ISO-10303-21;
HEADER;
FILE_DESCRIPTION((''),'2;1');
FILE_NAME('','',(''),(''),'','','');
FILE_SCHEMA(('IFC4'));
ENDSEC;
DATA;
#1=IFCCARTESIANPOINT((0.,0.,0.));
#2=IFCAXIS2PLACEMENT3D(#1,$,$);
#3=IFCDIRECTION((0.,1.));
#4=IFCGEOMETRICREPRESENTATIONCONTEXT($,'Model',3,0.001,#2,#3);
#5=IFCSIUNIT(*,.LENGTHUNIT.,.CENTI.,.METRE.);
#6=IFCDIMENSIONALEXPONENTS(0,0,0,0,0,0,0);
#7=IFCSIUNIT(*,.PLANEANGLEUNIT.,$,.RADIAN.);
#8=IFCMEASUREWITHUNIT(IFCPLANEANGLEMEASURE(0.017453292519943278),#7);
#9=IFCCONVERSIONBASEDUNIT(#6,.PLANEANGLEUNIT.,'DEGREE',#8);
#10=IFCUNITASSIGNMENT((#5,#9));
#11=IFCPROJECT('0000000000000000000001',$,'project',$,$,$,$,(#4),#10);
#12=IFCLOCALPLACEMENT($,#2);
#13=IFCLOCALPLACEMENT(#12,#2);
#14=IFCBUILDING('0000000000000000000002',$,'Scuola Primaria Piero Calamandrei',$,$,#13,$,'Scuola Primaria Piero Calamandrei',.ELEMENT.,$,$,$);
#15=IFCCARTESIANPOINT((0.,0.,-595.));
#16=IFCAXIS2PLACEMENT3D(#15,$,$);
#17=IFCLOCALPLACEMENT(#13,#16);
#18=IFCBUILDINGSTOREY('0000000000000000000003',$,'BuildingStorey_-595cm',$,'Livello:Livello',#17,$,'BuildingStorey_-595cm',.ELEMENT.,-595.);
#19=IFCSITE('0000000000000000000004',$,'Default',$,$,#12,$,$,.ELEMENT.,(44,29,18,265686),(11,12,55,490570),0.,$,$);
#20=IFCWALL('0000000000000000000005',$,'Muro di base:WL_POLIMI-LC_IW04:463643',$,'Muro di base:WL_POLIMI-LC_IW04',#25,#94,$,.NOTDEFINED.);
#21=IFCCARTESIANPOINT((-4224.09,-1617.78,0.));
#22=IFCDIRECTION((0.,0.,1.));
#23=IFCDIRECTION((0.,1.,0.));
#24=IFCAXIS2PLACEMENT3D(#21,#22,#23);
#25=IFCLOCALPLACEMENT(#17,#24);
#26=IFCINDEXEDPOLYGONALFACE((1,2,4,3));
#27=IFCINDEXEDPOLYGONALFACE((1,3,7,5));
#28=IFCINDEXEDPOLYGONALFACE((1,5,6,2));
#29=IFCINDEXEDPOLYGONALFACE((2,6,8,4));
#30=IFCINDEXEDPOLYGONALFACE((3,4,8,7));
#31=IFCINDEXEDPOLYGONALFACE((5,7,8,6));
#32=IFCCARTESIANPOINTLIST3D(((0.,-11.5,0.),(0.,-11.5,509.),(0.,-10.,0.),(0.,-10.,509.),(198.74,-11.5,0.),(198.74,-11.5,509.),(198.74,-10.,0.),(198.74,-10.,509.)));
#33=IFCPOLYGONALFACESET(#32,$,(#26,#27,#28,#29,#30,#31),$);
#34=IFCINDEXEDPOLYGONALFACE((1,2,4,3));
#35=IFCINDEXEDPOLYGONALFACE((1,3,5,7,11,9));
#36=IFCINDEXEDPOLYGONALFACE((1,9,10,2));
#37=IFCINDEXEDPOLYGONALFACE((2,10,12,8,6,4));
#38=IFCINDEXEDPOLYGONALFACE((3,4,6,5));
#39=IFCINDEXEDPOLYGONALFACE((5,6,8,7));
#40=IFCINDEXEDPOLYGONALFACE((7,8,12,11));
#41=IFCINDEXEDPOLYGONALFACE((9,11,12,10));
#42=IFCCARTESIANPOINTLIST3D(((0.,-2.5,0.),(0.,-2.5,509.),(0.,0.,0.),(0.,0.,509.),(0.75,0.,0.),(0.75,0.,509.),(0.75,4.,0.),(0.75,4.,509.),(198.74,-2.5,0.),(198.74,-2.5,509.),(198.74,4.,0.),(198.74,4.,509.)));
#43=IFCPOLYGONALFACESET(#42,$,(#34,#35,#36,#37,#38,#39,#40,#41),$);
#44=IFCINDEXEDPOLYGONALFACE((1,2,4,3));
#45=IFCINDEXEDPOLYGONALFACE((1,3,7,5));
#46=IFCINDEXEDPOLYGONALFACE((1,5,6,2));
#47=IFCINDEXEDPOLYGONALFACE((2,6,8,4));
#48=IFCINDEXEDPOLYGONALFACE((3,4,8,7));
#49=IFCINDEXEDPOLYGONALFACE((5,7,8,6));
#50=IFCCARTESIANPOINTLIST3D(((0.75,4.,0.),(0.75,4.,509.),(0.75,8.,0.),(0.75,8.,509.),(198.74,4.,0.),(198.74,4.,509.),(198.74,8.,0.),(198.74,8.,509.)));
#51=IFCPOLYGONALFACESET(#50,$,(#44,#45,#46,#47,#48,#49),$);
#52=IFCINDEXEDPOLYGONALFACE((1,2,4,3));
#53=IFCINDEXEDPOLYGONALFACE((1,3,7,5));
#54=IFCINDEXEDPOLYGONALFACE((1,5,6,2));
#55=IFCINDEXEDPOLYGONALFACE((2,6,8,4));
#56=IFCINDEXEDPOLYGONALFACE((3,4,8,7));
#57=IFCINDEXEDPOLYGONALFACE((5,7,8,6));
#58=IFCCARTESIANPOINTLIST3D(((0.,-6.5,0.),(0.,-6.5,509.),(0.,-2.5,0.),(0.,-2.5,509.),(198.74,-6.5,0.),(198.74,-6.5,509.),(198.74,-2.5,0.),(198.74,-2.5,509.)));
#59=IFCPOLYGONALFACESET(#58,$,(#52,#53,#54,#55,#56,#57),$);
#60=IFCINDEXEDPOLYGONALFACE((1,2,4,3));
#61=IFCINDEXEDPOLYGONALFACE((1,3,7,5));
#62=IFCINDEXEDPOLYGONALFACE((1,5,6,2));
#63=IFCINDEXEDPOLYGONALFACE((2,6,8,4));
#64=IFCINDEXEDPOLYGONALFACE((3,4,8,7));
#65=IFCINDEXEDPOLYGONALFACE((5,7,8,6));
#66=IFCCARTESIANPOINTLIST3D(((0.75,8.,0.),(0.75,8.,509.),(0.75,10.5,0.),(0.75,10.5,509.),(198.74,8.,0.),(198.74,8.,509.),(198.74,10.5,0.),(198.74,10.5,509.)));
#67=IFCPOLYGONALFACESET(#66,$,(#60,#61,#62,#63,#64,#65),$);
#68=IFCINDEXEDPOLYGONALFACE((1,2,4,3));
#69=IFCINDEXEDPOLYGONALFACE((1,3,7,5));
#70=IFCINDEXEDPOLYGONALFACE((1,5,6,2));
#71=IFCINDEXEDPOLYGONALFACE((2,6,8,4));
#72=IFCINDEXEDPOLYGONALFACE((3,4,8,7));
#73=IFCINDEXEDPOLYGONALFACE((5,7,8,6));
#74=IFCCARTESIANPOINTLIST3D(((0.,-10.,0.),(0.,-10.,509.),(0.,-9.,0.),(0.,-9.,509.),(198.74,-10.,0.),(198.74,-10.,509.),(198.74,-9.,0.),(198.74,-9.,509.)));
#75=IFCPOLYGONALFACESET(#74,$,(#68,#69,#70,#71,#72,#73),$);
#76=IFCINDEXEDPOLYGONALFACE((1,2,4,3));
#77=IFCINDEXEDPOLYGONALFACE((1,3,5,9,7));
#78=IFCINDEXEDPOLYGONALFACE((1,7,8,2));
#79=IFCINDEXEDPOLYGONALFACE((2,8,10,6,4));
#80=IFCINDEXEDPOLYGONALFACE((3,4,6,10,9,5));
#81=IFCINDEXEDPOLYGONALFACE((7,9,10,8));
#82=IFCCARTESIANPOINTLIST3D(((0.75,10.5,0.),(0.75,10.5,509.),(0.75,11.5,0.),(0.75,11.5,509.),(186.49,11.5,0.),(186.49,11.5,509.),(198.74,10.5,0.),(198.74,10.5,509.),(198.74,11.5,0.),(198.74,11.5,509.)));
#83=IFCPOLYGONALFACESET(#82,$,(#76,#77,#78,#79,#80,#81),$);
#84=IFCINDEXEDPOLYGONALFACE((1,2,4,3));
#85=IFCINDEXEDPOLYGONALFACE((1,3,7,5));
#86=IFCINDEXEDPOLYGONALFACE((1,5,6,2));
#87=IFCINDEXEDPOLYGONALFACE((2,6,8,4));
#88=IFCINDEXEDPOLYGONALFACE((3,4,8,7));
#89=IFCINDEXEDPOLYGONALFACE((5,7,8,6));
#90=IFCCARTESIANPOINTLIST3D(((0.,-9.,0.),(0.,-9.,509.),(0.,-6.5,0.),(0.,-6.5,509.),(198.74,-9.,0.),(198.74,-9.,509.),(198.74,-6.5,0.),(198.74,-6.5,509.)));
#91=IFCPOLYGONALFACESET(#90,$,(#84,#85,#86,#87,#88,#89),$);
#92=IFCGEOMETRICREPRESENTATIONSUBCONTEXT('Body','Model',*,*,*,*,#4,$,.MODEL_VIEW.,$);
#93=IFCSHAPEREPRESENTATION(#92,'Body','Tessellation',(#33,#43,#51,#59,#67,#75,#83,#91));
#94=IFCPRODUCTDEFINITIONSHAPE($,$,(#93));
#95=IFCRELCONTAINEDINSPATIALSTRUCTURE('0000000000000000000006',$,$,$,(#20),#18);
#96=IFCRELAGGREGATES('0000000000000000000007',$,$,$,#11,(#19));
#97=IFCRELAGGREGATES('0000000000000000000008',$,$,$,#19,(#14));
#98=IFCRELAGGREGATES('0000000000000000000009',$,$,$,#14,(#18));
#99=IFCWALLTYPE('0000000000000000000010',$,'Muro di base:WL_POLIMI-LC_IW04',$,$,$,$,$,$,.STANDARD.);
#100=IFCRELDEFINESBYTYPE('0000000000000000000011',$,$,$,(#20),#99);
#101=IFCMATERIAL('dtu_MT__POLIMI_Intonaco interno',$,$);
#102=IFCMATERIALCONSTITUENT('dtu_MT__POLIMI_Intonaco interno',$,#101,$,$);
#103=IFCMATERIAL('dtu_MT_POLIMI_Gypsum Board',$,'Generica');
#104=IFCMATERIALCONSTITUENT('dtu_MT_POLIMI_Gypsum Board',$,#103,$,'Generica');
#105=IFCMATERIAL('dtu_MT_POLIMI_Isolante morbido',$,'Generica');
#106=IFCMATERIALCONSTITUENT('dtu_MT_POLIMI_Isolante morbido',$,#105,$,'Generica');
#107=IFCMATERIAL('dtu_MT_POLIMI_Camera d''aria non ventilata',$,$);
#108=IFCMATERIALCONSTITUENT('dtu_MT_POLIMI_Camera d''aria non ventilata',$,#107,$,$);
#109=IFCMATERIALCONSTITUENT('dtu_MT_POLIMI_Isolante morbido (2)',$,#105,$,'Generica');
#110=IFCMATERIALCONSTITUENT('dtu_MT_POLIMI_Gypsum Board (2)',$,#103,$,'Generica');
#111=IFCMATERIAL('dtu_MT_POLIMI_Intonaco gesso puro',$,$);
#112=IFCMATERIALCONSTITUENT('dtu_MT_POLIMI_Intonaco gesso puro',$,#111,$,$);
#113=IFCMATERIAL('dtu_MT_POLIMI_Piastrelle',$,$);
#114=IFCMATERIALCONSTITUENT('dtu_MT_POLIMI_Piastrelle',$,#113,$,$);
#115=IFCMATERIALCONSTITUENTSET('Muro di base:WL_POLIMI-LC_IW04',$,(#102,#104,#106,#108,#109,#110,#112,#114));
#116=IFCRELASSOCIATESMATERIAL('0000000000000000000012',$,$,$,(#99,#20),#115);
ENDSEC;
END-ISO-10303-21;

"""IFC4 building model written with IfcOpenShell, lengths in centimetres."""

from ifc_helpers import new_model, entity, si_unit, converted_unit, direction, frame, origin, place, context, subcontext, project, spatial, indexed_curve, outline, extrude, material, constituent, constituent_set, type_object, element, save


model = new_model("IFC4")

# Units and contexts
model_context = context("Model", 3, precision=0.001, world=origin(), true_north=direction((0.0, 1.0)))
body_context = subcontext(model_context, "Body", "Model", "MODEL_VIEW")
ifc_project = project(units=[si_unit("LENGTHUNIT", "METRE", prefix="CENTI"), converted_unit("PLANEANGLEUNIT", "DEGREE", entity("IfcPlaneAngleMeasure", 0.017453292519943278), si_unit("PLANEANGLEUNIT", "RADIAN"), dimensions=[0, 0, 0, 0, 0, 0, 0])], contexts=[model_context])

# Site, building, storey
site_placement = place(None, origin())
site = spatial("IfcSite", under=ifc_project, at=site_placement, Name="Default", CompositionType="ELEMENT", RefLatitude=(44, 29, 18, 265686), RefLongitude=(11, 12, 55, 490570), RefElevation=0.0)
building_placement = place(site_placement, origin())
building = spatial("IfcBuilding", under=site, at=building_placement, Name="Scuola Primaria Piero Calamandrei", LongName="Scuola Primaria Piero Calamandrei", CompositionType="ELEMENT")
storey_placement = place(building_placement, frame((0.0, 0.0, -595.0)))
storey = spatial("IfcBuildingStorey", under=building, at=storey_placement, Name="BuildingStorey_-595cm", ObjectType="Livello:Livello", LongName="BuildingStorey_-595cm", CompositionType="ELEMENT", Elevation=-595.0)

# Shared definitions
ifc_material_1 = material(Name="dtu_MT__POLIMI_Intonaco interno")

# Shared definitions
ifc_material_2 = material(Name="dtu_MT_POLIMI_Gypsum Board", Category="Generica")
ifc_material_3 = material(Name="dtu_MT_POLIMI_Isolante morbido", Category="Generica")
ifc_material_4 = material(Name="dtu_MT_POLIMI_Camera d'aria non ventilata")
ifc_material_5 = material(Name="dtu_MT_POLIMI_Intonaco gesso puro")

# Shared definitions
ifc_constituent_1 = constituent(ifc_material_1, Name="dtu_MT__POLIMI_Intonaco interno")
ifc_constituent_2 = constituent(ifc_material_2, Name="dtu_MT_POLIMI_Gypsum Board", Category="Generica")
ifc_constituent_3 = constituent(ifc_material_3, Name="dtu_MT_POLIMI_Isolante morbido", Category="Generica")
ifc_constituent_4 = constituent(ifc_material_4, Name="dtu_MT_POLIMI_Camera d'aria non ventilata")
ifc_constituent_5 = constituent(ifc_material_3, Name="dtu_MT_POLIMI_Isolante morbido (2)", Category="Generica")
ifc_constituent_6 = constituent(ifc_material_2, Name="dtu_MT_POLIMI_Gypsum Board (2)", Category="Generica")
ifc_constituent_7 = constituent(ifc_material_5, Name="dtu_MT_POLIMI_Intonaco gesso puro")
ifc_material_6 = material(Name="dtu_MT_POLIMI_Piastrelle")
ifc_constituent_8 = constituent(ifc_material_6, Name="dtu_MT_POLIMI_Piastrelle")
ifc_constituent_set_1 = constituent_set(constituents=[ifc_constituent_1, ifc_constituent_2, ifc_constituent_3, ifc_constituent_4, ifc_constituent_5, ifc_constituent_6, ifc_constituent_7, ifc_constituent_8], Name="Muro di base:WL_POLIMI-LC_IW04")
wall_type_1 = type_object("IfcWallType", Name="Muro di base:WL_POLIMI-LC_IW04", PredefinedType="STANDARD", material=ifc_constituent_set_1)

# Wall
wall_1_placement = place(storey_placement, frame((-4224.09, -1617.78, 0.0), z_axis=(0.0, 0.0, 1.0), x_axis=(0.0, 1.0, 0.0)))
element("IfcWall", 1, at=wall_1_placement, inside=storey, type_object=wall_type_1, material=ifc_constituent_set_1, Name="Muro di base:WL_POLIMI-LC_IW04:463643", ObjectType="Muro di base:WL_POLIMI-LC_IW04", PredefinedType="NOTDEFINED", context=body_context, shape_type="SweptSolid", body=[
    extrude(outline(indexed_curve([(-0.75, -99.37), (0.75, -99.37), (0.75, 99.37), (-0.75, 99.37), (-0.75, -99.37)], self_intersect=False)), frame((99.37, -10.75, 0.0), z_axis=(0.0, 0.0, 1.0), x_axis=(0.0, 1.0, 0.0)), (0.0, 0.0, 1.0), 509.0),
    extrude(outline(indexed_curve([(0.5, -66.5), (3.0, -66.5), (3.0, 132.24), (-3.5, 132.24), (-3.5, -65.75), (0.5, -65.75), (0.5, -66.5)], self_intersect=False)), frame((66.5, 0.5, 0.0), z_axis=(0.0, 0.0, 1.0), x_axis=(0.0, -1.0, 0.0)), (0.0, 0.0, 1.0), 509.0),
    extrude(outline(indexed_curve([(-98.99, -2.0), (98.99, -2.0), (98.99, 2.0), (-98.99, 2.0), (-98.99, -2.0)], self_intersect=False)), frame((99.74, 6.0, 0.0)), (0.0, 0.0, 1.0), 509.0),
    extrude(outline(indexed_curve([(-99.37, -2.0), (99.37, -2.0), (99.37, 2.0), (-99.37, 2.0), (-99.37, -2.0)], self_intersect=False)), frame((99.37, -4.5, 0.0)), (0.0, 0.0, 1.0), 509.0),
    extrude(outline(indexed_curve([(-98.99, -1.25), (98.99, -1.25), (98.99, 1.25), (-98.99, 1.25), (-98.99, -1.25)], self_intersect=False)), frame((99.74, 9.25, 0.0)), (0.0, 0.0, 1.0), 509.0),
    extrude(outline(indexed_curve([(-99.37, -0.5), (99.37, -0.5), (99.37, 0.5), (-99.37, 0.5), (-99.37, -0.5)], self_intersect=False)), frame((99.37, -9.5, 0.0)), (0.0, 0.0, 1.0), 509.0),
    extrude(outline(indexed_curve([(-69.39, -0.4), (116.34, -0.4), (116.34, 0.6), (-81.64, 0.6), (-81.64, -0.4), (-69.39, -0.4)], self_intersect=False)), frame((117.09, 11.1, 0.0), z_axis=(0.0, 0.0, 1.0), x_axis=(-1.0, 0.0, 0.0)), (0.0, 0.0, 1.0), 509.0),
    extrude(outline(indexed_curve([(-99.37, -1.25), (99.37, -1.25), (99.37, 1.25), (-99.37, 1.25), (-99.37, -1.25)], self_intersect=False)), frame((99.37, -7.75, 0.0)), (0.0, 0.0, 1.0), 509.0),
])

save(model, "model.ifc")
